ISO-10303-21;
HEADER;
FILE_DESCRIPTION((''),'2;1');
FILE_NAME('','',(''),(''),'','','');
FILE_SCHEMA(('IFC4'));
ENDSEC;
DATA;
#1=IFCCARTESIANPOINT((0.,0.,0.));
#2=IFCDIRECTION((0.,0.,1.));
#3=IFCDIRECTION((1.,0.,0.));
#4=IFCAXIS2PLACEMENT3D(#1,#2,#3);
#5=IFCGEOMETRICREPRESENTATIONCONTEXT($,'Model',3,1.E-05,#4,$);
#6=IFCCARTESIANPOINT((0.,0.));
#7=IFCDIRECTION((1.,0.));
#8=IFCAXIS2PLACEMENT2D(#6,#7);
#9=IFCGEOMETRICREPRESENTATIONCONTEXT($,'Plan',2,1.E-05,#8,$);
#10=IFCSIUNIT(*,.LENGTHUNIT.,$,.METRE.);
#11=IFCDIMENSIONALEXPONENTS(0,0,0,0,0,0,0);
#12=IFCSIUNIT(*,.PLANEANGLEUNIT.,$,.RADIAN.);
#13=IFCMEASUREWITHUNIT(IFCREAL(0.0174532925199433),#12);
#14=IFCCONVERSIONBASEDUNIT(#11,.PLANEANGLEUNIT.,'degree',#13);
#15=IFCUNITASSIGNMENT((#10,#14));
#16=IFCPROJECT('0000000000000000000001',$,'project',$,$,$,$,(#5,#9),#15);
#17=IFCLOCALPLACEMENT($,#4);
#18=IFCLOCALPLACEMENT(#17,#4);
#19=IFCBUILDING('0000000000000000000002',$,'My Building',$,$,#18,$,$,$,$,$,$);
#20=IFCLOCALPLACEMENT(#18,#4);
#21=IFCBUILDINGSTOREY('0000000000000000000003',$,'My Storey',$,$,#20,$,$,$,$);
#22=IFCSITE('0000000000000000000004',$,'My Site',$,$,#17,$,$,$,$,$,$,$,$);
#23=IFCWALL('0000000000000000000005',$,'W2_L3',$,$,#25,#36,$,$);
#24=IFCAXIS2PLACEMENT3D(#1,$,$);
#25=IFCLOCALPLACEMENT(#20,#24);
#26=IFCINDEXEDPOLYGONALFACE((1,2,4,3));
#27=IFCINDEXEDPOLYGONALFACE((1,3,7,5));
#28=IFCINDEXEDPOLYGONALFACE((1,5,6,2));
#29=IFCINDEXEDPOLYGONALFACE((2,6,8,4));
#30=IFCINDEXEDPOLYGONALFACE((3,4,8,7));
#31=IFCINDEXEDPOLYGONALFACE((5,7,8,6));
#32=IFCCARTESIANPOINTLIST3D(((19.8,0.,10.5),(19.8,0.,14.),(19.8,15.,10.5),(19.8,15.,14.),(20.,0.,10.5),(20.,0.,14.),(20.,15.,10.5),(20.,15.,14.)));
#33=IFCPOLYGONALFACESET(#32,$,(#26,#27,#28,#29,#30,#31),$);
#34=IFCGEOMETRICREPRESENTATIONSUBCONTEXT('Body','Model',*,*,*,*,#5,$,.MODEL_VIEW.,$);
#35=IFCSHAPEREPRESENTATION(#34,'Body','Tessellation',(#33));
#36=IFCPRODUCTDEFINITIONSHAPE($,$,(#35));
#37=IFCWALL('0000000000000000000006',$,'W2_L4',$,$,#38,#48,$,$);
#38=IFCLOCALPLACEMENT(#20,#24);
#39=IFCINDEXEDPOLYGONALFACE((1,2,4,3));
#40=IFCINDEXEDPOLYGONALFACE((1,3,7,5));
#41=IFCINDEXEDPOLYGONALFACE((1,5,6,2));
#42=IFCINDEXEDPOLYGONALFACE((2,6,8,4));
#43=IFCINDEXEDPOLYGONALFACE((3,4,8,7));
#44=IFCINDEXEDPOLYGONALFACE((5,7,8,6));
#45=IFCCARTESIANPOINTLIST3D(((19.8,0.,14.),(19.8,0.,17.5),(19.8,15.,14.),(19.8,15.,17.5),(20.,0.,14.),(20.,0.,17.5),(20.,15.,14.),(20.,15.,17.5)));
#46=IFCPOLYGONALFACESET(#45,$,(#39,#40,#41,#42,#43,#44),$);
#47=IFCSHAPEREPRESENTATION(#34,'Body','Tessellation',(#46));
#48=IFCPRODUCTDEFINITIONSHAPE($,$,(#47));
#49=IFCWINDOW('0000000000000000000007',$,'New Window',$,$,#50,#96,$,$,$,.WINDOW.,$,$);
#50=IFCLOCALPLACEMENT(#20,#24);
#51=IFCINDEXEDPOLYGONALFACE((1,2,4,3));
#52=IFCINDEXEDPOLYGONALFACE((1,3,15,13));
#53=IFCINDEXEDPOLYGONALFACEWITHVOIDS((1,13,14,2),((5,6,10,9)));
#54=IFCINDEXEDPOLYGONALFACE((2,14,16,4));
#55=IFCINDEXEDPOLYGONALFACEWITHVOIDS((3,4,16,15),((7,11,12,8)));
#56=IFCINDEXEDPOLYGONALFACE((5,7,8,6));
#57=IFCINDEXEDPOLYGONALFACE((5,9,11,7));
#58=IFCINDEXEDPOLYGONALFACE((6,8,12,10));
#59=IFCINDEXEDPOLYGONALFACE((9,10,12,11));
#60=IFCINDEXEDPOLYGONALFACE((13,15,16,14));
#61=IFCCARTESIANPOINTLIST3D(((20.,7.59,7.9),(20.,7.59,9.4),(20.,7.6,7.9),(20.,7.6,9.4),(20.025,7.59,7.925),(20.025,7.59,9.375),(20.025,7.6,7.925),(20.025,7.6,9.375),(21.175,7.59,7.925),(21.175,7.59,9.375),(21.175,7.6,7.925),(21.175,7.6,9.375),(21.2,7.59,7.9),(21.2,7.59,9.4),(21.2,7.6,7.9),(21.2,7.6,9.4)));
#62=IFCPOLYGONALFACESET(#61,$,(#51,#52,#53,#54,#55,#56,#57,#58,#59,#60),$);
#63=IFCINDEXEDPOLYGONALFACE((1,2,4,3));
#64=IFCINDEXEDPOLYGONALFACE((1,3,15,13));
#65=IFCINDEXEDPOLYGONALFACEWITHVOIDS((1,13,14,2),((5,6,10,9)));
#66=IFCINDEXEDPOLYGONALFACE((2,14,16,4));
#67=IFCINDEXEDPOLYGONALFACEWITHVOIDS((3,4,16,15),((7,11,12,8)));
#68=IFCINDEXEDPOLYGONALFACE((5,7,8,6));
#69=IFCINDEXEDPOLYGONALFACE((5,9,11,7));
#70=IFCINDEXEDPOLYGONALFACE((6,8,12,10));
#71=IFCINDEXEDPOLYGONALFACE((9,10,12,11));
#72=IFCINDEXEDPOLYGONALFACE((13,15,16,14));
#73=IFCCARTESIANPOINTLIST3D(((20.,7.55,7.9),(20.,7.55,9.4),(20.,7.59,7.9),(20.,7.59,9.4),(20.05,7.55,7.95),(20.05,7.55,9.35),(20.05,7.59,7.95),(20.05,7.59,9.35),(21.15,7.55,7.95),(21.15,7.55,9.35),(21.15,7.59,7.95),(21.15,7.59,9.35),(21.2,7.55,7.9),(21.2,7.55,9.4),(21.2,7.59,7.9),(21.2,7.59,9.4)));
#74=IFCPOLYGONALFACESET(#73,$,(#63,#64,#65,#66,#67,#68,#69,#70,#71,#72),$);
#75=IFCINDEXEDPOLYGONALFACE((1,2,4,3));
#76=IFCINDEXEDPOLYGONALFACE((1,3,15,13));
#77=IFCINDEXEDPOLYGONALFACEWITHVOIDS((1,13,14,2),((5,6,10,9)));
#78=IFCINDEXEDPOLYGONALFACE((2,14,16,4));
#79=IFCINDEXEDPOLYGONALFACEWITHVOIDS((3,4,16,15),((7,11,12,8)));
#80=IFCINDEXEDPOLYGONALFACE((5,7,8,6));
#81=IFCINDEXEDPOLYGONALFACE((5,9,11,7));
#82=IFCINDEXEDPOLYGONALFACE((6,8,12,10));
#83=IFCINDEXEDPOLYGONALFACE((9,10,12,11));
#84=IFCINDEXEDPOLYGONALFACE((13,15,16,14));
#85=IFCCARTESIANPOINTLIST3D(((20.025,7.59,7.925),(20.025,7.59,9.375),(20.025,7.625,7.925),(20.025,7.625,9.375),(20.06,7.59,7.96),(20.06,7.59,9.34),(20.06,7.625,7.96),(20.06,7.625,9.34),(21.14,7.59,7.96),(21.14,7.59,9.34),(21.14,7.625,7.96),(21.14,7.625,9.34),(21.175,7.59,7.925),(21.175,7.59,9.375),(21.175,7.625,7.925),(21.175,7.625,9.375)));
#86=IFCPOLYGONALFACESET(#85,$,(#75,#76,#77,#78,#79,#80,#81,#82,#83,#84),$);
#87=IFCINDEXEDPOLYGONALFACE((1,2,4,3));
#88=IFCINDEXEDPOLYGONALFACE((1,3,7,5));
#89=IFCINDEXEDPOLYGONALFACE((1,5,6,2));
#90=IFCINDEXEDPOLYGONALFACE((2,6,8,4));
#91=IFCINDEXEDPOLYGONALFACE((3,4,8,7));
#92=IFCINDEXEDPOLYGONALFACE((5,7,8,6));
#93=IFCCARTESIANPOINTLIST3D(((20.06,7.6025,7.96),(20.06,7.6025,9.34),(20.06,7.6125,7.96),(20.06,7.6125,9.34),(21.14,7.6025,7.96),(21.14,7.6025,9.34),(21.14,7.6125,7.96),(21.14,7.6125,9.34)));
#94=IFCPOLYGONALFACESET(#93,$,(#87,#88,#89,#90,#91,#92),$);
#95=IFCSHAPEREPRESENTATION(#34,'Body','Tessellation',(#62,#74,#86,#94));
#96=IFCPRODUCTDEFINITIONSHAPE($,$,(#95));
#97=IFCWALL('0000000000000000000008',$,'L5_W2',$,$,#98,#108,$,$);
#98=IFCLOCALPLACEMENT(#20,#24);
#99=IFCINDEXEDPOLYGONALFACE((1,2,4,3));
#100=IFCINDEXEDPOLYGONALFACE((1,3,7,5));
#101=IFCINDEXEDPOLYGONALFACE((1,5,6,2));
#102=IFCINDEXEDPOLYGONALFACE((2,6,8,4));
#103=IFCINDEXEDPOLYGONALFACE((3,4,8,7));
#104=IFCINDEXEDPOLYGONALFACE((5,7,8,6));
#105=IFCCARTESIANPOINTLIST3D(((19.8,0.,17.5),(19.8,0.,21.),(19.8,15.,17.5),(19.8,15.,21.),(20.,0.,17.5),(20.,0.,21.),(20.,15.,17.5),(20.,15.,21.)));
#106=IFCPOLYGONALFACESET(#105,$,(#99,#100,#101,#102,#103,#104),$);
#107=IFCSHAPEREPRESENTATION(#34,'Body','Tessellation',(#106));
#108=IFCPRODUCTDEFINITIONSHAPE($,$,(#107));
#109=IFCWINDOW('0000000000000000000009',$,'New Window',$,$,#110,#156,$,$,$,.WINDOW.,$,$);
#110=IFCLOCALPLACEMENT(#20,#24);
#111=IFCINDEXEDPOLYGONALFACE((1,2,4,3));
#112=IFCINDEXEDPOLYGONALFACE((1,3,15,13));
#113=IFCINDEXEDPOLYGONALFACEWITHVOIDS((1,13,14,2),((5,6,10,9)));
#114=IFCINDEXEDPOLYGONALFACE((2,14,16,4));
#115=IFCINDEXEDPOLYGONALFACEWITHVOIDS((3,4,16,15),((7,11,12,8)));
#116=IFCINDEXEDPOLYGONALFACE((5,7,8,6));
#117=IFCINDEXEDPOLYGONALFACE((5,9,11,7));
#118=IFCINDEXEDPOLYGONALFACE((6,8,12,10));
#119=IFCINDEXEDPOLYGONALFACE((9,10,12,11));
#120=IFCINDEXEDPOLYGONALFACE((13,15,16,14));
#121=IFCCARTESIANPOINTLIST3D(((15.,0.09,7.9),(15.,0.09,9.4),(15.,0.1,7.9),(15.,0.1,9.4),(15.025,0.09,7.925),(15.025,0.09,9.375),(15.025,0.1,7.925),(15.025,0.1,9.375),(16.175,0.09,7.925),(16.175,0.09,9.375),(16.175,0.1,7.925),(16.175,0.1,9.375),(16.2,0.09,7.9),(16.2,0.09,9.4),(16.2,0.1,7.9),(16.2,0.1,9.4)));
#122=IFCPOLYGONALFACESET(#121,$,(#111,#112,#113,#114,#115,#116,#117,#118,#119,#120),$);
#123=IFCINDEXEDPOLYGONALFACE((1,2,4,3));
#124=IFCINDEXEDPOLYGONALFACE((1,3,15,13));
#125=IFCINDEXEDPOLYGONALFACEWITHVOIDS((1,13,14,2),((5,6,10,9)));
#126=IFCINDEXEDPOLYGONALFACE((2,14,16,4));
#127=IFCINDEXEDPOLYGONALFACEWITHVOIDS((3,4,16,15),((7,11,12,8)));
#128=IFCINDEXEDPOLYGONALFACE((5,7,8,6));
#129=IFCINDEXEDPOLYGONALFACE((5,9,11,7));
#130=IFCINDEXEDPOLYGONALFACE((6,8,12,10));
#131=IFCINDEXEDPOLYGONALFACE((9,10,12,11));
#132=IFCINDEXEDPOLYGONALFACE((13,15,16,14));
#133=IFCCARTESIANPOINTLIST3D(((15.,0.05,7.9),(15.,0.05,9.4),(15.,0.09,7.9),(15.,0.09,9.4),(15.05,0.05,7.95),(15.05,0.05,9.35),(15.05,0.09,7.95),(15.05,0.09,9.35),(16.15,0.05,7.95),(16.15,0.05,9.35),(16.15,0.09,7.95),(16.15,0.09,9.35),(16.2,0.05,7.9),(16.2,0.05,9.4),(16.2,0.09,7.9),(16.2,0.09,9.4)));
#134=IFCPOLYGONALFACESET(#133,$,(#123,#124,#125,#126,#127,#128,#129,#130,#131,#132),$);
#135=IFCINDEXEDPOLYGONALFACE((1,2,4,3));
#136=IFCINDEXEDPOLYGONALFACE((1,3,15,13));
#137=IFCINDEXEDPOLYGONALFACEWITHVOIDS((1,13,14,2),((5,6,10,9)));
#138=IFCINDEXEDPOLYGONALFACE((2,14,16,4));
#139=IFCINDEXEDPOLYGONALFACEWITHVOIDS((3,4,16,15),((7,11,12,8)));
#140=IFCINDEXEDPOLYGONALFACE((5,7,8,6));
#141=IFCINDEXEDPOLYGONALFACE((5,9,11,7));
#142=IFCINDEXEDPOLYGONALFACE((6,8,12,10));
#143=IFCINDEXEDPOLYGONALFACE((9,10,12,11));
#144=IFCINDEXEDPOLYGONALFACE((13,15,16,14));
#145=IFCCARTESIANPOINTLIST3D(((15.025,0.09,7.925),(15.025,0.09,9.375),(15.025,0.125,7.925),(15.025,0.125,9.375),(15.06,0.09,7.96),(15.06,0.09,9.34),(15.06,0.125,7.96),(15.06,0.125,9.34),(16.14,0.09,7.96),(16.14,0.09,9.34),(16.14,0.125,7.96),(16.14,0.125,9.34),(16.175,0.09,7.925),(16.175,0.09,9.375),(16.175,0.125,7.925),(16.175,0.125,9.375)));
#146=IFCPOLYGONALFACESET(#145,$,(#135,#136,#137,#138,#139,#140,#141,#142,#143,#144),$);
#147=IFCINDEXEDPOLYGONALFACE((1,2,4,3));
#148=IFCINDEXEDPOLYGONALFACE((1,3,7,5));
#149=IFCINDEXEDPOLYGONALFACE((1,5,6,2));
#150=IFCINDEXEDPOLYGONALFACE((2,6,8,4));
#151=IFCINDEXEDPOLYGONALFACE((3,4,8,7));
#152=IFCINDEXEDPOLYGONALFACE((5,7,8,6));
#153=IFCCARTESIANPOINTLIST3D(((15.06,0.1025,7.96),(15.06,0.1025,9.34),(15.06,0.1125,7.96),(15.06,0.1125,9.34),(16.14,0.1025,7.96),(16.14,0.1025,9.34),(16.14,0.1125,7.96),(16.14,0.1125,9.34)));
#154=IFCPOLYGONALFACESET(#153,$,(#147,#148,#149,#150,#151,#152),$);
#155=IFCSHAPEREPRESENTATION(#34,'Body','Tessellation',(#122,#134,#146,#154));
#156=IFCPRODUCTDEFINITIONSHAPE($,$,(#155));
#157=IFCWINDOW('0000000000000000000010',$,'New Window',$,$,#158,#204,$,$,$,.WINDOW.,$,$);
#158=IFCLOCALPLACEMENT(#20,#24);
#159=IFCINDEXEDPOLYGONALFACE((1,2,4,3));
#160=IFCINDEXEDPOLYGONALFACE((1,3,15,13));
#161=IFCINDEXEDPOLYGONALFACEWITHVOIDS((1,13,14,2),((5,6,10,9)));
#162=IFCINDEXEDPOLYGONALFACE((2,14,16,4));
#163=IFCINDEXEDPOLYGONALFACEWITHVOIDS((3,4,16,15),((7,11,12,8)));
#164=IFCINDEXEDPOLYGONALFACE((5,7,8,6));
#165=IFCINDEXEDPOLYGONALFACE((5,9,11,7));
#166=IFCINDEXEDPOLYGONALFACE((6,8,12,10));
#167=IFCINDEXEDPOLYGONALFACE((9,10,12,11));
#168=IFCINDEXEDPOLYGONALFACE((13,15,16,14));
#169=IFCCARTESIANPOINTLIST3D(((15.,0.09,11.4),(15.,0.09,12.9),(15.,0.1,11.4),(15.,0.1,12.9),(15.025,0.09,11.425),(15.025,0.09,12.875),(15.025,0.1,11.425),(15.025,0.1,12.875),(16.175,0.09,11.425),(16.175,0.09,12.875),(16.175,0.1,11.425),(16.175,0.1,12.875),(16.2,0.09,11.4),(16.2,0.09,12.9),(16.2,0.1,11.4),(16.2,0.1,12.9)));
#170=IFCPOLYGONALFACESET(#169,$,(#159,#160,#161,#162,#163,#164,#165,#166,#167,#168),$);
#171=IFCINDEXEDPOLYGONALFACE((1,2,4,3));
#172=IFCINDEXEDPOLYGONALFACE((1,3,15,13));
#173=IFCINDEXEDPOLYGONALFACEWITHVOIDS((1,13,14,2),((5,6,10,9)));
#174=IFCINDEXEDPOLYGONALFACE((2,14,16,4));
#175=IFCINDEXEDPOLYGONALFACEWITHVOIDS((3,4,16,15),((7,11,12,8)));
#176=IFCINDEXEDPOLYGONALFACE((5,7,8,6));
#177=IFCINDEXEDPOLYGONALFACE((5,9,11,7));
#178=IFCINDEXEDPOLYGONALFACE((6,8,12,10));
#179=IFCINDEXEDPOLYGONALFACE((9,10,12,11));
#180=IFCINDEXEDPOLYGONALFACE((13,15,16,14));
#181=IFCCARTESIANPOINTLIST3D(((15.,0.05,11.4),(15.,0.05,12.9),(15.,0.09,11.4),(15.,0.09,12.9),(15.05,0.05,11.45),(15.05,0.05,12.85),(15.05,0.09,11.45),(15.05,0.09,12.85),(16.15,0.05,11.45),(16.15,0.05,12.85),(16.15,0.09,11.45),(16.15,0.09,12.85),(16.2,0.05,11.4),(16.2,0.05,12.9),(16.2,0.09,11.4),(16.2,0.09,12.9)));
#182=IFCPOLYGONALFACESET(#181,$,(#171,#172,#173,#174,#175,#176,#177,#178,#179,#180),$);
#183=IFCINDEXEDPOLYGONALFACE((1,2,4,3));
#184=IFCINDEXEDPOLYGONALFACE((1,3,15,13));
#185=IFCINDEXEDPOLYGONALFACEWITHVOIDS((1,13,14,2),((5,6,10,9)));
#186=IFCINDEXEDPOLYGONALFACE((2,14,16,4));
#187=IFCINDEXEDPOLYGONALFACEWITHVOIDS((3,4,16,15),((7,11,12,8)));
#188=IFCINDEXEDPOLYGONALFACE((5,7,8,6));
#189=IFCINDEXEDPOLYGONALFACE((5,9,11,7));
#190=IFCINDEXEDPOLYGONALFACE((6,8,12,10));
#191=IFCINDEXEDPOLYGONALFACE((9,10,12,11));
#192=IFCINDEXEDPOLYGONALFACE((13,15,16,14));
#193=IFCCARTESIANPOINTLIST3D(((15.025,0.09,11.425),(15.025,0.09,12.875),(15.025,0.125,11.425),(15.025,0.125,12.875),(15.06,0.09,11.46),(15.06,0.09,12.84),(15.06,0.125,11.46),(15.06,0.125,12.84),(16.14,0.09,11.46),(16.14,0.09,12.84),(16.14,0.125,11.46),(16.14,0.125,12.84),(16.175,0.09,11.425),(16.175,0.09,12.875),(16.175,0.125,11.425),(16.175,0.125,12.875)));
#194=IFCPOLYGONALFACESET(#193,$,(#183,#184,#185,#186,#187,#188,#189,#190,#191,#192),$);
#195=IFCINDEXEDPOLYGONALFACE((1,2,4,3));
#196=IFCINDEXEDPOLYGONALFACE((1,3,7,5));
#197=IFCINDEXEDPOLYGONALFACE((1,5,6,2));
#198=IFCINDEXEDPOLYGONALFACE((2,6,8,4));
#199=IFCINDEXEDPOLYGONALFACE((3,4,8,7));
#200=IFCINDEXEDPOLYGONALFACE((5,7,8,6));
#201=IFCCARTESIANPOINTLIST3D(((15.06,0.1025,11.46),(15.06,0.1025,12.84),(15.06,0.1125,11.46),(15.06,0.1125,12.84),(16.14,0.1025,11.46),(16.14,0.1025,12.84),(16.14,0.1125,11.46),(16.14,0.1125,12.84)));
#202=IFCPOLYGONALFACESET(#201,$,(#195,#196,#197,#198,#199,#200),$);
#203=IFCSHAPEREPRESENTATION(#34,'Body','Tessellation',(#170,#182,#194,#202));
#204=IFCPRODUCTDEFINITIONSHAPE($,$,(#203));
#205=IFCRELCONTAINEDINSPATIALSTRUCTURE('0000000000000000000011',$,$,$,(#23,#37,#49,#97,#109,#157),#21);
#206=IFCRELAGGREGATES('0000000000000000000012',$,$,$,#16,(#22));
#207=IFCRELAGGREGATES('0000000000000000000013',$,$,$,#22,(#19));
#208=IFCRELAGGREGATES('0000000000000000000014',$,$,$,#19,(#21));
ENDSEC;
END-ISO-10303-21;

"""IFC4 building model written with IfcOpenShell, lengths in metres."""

from ifc_helpers import new_model, entity, si_unit, converted_unit, frame, origin_with_axes, origin_2d_with_axis, place, context, subcontext, project, spatial, line, indexed_curve, outline, extrude, element, save


model = new_model("IFC4")

# Units and contexts
model_context = context("Model", 3, precision=1e-05, world=origin_with_axes())
plan_context = context("Plan", 2, precision=1e-05, world=origin_2d_with_axis())
body_context = subcontext(model_context, "Body", "Model", "MODEL_VIEW")
ifc_project = project(units=[si_unit("LENGTHUNIT", "METRE"), converted_unit("PLANEANGLEUNIT", "degree", entity("IfcReal", 0.0174532925199433), si_unit("PLANEANGLEUNIT", "RADIAN"), dimensions=[0, 0, 0, 0, 0, 0, 0])], contexts=[model_context, plan_context])

# Site, building, storey
site_placement = place(None, origin_with_axes())
site = spatial("IfcSite", under=ifc_project, at=site_placement, Name="My Site")
building_placement = place(site_placement, origin_with_axes())
building = spatial("IfcBuilding", under=site, at=building_placement, Name="My Building")
storey_placement = place(building_placement, origin_with_axes())
storey = spatial("IfcBuildingStorey", under=building, at=storey_placement, Name="My Storey")

# Walls
for number, where, z_axis, x_axis, name in (
    (1, (20.0, 0.0, 10.5), (0.0, 0.0, 1.0), (0.0, 1.0, 0.0), "W2_L3"),
    (2, (20.0, 0.0, 14.0), (0.0, 0.0, 1.0), (0.0, 1.0, 0.0), "W2_L4"),
):
    element("IfcWall", number, at=place(storey_placement, frame(where, z_axis=z_axis, x_axis=x_axis)), inside=storey, Name=name, context=body_context, shape_type="SweptSolid", body=[
        extrude(outline(indexed_curve([(0.0, 0.0), (0.0, 0.2), (15.0, 0.2), (15.0, 0.0), (0.0, 0.0)], self_intersect=False)), origin_with_axes(), (0.0, 0.0, 1.0), 3.5),
    ])

# Window
window_placement = place(storey_placement, frame((20.0, 7.5, 7.9), z_axis=(0.0, 0.0, 1.0), x_axis=(1.0, 0.0, 0.0)))
element("IfcWindow", 3, at=window_placement, inside=storey, Name="New Window", PredefinedType="WINDOW", context=body_context, shape_type="SweptSolid", body=[
    extrude(outline(indexed_curve([(0.0, 0.0), (1.2, 0.0), (1.2, 1.5), (0.0, 1.5)], segments=[line(1, 2, 3, 4, 1)]), holes=[indexed_curve([(0.025, 0.025), (1.175, 0.025), (1.175, 1.475), (0.025, 1.475)], segments=[line(1, 2, 3, 4, 1)])]), frame((0.0, 0.09, 0.0), z_axis=(0.0, -1.0, 0.0), x_axis=(1.0, 0.0, 0.0)), (0.0, 0.0, -1.0), 0.01),
    extrude(outline(indexed_curve([(0.0, 0.0), (1.2, 0.0), (1.2, 1.5), (0.0, 1.5)], segments=[line(1, 2, 3, 4, 1)]), holes=[indexed_curve([(0.05, 0.05), (1.15, 0.05), (1.15, 1.45), (0.05, 1.45)], segments=[line(1, 2, 3, 4, 1)])]), frame((0.0, 0.05, 0.0), z_axis=(0.0, -1.0, 0.0), x_axis=(1.0, 0.0, 0.0)), (0.0, 0.0, -1.0), 0.04),
    extrude(outline(indexed_curve([(0.0, 0.0), (1.15, 0.0), (1.15, 1.45), (0.0, 1.45)], segments=[line(1, 2, 3, 4, 1)]), holes=[indexed_curve([(0.035, 0.035), (1.115, 0.035), (1.115, 1.415), (0.035, 1.415)], segments=[line(1, 2, 3, 4, 1)])]), frame((0.025, 0.09, 0.025), z_axis=(0.0, -1.0, 0.0), x_axis=(1.0, 0.0, 0.0)), (0.0, 0.0, -1.0), 0.035),
    extrude(outline(indexed_curve([(0.035, 0.035), (1.115, 0.035), (1.115, 1.415), (0.035, 1.415)], segments=[line(1, 2, 3, 4, 1)])), frame((0.025, 0.1025, 0.025), z_axis=(0.0, -1.0, 0.0), x_axis=(1.0, 0.0, 0.0)), (0.0, 0.0, -1.0), 0.01),
])

# Wall
for number, where, z_axis, x_axis, name in (
    (4, (20.0, 0.0, 17.5), (0.0, 0.0, 1.0), (0.0, 1.0, 0.0), "L5_W2"),
):
    element("IfcWall", number, at=place(storey_placement, frame(where, z_axis=z_axis, x_axis=x_axis)), inside=storey, Name=name, context=body_context, shape_type="SweptSolid", body=[
        extrude(outline(indexed_curve([(0.0, 0.0), (0.0, 0.2), (15.0, 0.2), (15.0, 0.0), (0.0, 0.0)], self_intersect=False)), origin_with_axes(), (0.0, 0.0, 1.0), 3.5),
    ])

# Windows
for number, where, z_axis, x_axis, name in (
    (5, (15.0, 0.0, 7.9), (0.0, 0.0, 1.0), (1.0, 0.0, 0.0), "New Window"),
    (6, (15.0, 0.0, 11.4), (0.0, 0.0, 1.0), (1.0, 0.0, 0.0), "New Window"),
):
    element("IfcWindow", number, at=place(storey_placement, frame(where, z_axis=z_axis, x_axis=x_axis)), inside=storey, Name=name, PredefinedType="WINDOW", context=body_context, shape_type="SweptSolid", body=[
        extrude(outline(indexed_curve([(0.0, 0.0), (1.2, 0.0), (1.2, 1.5), (0.0, 1.5)], segments=[line(1, 2, 3, 4, 1)]), holes=[indexed_curve([(0.025, 0.025), (1.175, 0.025), (1.175, 1.475), (0.025, 1.475)], segments=[line(1, 2, 3, 4, 1)])]), frame((0.0, 0.09, 0.0), z_axis=(0.0, -1.0, 0.0), x_axis=(1.0, 0.0, 0.0)), (0.0, 0.0, -1.0), 0.01),
        extrude(outline(indexed_curve([(0.0, 0.0), (1.2, 0.0), (1.2, 1.5), (0.0, 1.5)], segments=[line(1, 2, 3, 4, 1)]), holes=[indexed_curve([(0.05, 0.05), (1.15, 0.05), (1.15, 1.45), (0.05, 1.45)], segments=[line(1, 2, 3, 4, 1)])]), frame((0.0, 0.05, 0.0), z_axis=(0.0, -1.0, 0.0), x_axis=(1.0, 0.0, 0.0)), (0.0, 0.0, -1.0), 0.04),
        extrude(outline(indexed_curve([(0.0, 0.0), (1.15, 0.0), (1.15, 1.45), (0.0, 1.45)], segments=[line(1, 2, 3, 4, 1)]), holes=[indexed_curve([(0.035, 0.035), (1.115, 0.035), (1.115, 1.415), (0.035, 1.415)], segments=[line(1, 2, 3, 4, 1)])]), frame((0.025, 0.09, 0.025), z_axis=(0.0, -1.0, 0.0), x_axis=(1.0, 0.0, 0.0)), (0.0, 0.0, -1.0), 0.035),
        extrude(outline(indexed_curve([(0.035, 0.035), (1.115, 0.035), (1.115, 1.415), (0.035, 1.415)], segments=[line(1, 2, 3, 4, 1)])), frame((0.025, 0.1025, 0.025), z_axis=(0.0, -1.0, 0.0), x_axis=(1.0, 0.0, 0.0)), (0.0, 0.0, -1.0), 0.01),
    ])

save(model, "model.ifc")
